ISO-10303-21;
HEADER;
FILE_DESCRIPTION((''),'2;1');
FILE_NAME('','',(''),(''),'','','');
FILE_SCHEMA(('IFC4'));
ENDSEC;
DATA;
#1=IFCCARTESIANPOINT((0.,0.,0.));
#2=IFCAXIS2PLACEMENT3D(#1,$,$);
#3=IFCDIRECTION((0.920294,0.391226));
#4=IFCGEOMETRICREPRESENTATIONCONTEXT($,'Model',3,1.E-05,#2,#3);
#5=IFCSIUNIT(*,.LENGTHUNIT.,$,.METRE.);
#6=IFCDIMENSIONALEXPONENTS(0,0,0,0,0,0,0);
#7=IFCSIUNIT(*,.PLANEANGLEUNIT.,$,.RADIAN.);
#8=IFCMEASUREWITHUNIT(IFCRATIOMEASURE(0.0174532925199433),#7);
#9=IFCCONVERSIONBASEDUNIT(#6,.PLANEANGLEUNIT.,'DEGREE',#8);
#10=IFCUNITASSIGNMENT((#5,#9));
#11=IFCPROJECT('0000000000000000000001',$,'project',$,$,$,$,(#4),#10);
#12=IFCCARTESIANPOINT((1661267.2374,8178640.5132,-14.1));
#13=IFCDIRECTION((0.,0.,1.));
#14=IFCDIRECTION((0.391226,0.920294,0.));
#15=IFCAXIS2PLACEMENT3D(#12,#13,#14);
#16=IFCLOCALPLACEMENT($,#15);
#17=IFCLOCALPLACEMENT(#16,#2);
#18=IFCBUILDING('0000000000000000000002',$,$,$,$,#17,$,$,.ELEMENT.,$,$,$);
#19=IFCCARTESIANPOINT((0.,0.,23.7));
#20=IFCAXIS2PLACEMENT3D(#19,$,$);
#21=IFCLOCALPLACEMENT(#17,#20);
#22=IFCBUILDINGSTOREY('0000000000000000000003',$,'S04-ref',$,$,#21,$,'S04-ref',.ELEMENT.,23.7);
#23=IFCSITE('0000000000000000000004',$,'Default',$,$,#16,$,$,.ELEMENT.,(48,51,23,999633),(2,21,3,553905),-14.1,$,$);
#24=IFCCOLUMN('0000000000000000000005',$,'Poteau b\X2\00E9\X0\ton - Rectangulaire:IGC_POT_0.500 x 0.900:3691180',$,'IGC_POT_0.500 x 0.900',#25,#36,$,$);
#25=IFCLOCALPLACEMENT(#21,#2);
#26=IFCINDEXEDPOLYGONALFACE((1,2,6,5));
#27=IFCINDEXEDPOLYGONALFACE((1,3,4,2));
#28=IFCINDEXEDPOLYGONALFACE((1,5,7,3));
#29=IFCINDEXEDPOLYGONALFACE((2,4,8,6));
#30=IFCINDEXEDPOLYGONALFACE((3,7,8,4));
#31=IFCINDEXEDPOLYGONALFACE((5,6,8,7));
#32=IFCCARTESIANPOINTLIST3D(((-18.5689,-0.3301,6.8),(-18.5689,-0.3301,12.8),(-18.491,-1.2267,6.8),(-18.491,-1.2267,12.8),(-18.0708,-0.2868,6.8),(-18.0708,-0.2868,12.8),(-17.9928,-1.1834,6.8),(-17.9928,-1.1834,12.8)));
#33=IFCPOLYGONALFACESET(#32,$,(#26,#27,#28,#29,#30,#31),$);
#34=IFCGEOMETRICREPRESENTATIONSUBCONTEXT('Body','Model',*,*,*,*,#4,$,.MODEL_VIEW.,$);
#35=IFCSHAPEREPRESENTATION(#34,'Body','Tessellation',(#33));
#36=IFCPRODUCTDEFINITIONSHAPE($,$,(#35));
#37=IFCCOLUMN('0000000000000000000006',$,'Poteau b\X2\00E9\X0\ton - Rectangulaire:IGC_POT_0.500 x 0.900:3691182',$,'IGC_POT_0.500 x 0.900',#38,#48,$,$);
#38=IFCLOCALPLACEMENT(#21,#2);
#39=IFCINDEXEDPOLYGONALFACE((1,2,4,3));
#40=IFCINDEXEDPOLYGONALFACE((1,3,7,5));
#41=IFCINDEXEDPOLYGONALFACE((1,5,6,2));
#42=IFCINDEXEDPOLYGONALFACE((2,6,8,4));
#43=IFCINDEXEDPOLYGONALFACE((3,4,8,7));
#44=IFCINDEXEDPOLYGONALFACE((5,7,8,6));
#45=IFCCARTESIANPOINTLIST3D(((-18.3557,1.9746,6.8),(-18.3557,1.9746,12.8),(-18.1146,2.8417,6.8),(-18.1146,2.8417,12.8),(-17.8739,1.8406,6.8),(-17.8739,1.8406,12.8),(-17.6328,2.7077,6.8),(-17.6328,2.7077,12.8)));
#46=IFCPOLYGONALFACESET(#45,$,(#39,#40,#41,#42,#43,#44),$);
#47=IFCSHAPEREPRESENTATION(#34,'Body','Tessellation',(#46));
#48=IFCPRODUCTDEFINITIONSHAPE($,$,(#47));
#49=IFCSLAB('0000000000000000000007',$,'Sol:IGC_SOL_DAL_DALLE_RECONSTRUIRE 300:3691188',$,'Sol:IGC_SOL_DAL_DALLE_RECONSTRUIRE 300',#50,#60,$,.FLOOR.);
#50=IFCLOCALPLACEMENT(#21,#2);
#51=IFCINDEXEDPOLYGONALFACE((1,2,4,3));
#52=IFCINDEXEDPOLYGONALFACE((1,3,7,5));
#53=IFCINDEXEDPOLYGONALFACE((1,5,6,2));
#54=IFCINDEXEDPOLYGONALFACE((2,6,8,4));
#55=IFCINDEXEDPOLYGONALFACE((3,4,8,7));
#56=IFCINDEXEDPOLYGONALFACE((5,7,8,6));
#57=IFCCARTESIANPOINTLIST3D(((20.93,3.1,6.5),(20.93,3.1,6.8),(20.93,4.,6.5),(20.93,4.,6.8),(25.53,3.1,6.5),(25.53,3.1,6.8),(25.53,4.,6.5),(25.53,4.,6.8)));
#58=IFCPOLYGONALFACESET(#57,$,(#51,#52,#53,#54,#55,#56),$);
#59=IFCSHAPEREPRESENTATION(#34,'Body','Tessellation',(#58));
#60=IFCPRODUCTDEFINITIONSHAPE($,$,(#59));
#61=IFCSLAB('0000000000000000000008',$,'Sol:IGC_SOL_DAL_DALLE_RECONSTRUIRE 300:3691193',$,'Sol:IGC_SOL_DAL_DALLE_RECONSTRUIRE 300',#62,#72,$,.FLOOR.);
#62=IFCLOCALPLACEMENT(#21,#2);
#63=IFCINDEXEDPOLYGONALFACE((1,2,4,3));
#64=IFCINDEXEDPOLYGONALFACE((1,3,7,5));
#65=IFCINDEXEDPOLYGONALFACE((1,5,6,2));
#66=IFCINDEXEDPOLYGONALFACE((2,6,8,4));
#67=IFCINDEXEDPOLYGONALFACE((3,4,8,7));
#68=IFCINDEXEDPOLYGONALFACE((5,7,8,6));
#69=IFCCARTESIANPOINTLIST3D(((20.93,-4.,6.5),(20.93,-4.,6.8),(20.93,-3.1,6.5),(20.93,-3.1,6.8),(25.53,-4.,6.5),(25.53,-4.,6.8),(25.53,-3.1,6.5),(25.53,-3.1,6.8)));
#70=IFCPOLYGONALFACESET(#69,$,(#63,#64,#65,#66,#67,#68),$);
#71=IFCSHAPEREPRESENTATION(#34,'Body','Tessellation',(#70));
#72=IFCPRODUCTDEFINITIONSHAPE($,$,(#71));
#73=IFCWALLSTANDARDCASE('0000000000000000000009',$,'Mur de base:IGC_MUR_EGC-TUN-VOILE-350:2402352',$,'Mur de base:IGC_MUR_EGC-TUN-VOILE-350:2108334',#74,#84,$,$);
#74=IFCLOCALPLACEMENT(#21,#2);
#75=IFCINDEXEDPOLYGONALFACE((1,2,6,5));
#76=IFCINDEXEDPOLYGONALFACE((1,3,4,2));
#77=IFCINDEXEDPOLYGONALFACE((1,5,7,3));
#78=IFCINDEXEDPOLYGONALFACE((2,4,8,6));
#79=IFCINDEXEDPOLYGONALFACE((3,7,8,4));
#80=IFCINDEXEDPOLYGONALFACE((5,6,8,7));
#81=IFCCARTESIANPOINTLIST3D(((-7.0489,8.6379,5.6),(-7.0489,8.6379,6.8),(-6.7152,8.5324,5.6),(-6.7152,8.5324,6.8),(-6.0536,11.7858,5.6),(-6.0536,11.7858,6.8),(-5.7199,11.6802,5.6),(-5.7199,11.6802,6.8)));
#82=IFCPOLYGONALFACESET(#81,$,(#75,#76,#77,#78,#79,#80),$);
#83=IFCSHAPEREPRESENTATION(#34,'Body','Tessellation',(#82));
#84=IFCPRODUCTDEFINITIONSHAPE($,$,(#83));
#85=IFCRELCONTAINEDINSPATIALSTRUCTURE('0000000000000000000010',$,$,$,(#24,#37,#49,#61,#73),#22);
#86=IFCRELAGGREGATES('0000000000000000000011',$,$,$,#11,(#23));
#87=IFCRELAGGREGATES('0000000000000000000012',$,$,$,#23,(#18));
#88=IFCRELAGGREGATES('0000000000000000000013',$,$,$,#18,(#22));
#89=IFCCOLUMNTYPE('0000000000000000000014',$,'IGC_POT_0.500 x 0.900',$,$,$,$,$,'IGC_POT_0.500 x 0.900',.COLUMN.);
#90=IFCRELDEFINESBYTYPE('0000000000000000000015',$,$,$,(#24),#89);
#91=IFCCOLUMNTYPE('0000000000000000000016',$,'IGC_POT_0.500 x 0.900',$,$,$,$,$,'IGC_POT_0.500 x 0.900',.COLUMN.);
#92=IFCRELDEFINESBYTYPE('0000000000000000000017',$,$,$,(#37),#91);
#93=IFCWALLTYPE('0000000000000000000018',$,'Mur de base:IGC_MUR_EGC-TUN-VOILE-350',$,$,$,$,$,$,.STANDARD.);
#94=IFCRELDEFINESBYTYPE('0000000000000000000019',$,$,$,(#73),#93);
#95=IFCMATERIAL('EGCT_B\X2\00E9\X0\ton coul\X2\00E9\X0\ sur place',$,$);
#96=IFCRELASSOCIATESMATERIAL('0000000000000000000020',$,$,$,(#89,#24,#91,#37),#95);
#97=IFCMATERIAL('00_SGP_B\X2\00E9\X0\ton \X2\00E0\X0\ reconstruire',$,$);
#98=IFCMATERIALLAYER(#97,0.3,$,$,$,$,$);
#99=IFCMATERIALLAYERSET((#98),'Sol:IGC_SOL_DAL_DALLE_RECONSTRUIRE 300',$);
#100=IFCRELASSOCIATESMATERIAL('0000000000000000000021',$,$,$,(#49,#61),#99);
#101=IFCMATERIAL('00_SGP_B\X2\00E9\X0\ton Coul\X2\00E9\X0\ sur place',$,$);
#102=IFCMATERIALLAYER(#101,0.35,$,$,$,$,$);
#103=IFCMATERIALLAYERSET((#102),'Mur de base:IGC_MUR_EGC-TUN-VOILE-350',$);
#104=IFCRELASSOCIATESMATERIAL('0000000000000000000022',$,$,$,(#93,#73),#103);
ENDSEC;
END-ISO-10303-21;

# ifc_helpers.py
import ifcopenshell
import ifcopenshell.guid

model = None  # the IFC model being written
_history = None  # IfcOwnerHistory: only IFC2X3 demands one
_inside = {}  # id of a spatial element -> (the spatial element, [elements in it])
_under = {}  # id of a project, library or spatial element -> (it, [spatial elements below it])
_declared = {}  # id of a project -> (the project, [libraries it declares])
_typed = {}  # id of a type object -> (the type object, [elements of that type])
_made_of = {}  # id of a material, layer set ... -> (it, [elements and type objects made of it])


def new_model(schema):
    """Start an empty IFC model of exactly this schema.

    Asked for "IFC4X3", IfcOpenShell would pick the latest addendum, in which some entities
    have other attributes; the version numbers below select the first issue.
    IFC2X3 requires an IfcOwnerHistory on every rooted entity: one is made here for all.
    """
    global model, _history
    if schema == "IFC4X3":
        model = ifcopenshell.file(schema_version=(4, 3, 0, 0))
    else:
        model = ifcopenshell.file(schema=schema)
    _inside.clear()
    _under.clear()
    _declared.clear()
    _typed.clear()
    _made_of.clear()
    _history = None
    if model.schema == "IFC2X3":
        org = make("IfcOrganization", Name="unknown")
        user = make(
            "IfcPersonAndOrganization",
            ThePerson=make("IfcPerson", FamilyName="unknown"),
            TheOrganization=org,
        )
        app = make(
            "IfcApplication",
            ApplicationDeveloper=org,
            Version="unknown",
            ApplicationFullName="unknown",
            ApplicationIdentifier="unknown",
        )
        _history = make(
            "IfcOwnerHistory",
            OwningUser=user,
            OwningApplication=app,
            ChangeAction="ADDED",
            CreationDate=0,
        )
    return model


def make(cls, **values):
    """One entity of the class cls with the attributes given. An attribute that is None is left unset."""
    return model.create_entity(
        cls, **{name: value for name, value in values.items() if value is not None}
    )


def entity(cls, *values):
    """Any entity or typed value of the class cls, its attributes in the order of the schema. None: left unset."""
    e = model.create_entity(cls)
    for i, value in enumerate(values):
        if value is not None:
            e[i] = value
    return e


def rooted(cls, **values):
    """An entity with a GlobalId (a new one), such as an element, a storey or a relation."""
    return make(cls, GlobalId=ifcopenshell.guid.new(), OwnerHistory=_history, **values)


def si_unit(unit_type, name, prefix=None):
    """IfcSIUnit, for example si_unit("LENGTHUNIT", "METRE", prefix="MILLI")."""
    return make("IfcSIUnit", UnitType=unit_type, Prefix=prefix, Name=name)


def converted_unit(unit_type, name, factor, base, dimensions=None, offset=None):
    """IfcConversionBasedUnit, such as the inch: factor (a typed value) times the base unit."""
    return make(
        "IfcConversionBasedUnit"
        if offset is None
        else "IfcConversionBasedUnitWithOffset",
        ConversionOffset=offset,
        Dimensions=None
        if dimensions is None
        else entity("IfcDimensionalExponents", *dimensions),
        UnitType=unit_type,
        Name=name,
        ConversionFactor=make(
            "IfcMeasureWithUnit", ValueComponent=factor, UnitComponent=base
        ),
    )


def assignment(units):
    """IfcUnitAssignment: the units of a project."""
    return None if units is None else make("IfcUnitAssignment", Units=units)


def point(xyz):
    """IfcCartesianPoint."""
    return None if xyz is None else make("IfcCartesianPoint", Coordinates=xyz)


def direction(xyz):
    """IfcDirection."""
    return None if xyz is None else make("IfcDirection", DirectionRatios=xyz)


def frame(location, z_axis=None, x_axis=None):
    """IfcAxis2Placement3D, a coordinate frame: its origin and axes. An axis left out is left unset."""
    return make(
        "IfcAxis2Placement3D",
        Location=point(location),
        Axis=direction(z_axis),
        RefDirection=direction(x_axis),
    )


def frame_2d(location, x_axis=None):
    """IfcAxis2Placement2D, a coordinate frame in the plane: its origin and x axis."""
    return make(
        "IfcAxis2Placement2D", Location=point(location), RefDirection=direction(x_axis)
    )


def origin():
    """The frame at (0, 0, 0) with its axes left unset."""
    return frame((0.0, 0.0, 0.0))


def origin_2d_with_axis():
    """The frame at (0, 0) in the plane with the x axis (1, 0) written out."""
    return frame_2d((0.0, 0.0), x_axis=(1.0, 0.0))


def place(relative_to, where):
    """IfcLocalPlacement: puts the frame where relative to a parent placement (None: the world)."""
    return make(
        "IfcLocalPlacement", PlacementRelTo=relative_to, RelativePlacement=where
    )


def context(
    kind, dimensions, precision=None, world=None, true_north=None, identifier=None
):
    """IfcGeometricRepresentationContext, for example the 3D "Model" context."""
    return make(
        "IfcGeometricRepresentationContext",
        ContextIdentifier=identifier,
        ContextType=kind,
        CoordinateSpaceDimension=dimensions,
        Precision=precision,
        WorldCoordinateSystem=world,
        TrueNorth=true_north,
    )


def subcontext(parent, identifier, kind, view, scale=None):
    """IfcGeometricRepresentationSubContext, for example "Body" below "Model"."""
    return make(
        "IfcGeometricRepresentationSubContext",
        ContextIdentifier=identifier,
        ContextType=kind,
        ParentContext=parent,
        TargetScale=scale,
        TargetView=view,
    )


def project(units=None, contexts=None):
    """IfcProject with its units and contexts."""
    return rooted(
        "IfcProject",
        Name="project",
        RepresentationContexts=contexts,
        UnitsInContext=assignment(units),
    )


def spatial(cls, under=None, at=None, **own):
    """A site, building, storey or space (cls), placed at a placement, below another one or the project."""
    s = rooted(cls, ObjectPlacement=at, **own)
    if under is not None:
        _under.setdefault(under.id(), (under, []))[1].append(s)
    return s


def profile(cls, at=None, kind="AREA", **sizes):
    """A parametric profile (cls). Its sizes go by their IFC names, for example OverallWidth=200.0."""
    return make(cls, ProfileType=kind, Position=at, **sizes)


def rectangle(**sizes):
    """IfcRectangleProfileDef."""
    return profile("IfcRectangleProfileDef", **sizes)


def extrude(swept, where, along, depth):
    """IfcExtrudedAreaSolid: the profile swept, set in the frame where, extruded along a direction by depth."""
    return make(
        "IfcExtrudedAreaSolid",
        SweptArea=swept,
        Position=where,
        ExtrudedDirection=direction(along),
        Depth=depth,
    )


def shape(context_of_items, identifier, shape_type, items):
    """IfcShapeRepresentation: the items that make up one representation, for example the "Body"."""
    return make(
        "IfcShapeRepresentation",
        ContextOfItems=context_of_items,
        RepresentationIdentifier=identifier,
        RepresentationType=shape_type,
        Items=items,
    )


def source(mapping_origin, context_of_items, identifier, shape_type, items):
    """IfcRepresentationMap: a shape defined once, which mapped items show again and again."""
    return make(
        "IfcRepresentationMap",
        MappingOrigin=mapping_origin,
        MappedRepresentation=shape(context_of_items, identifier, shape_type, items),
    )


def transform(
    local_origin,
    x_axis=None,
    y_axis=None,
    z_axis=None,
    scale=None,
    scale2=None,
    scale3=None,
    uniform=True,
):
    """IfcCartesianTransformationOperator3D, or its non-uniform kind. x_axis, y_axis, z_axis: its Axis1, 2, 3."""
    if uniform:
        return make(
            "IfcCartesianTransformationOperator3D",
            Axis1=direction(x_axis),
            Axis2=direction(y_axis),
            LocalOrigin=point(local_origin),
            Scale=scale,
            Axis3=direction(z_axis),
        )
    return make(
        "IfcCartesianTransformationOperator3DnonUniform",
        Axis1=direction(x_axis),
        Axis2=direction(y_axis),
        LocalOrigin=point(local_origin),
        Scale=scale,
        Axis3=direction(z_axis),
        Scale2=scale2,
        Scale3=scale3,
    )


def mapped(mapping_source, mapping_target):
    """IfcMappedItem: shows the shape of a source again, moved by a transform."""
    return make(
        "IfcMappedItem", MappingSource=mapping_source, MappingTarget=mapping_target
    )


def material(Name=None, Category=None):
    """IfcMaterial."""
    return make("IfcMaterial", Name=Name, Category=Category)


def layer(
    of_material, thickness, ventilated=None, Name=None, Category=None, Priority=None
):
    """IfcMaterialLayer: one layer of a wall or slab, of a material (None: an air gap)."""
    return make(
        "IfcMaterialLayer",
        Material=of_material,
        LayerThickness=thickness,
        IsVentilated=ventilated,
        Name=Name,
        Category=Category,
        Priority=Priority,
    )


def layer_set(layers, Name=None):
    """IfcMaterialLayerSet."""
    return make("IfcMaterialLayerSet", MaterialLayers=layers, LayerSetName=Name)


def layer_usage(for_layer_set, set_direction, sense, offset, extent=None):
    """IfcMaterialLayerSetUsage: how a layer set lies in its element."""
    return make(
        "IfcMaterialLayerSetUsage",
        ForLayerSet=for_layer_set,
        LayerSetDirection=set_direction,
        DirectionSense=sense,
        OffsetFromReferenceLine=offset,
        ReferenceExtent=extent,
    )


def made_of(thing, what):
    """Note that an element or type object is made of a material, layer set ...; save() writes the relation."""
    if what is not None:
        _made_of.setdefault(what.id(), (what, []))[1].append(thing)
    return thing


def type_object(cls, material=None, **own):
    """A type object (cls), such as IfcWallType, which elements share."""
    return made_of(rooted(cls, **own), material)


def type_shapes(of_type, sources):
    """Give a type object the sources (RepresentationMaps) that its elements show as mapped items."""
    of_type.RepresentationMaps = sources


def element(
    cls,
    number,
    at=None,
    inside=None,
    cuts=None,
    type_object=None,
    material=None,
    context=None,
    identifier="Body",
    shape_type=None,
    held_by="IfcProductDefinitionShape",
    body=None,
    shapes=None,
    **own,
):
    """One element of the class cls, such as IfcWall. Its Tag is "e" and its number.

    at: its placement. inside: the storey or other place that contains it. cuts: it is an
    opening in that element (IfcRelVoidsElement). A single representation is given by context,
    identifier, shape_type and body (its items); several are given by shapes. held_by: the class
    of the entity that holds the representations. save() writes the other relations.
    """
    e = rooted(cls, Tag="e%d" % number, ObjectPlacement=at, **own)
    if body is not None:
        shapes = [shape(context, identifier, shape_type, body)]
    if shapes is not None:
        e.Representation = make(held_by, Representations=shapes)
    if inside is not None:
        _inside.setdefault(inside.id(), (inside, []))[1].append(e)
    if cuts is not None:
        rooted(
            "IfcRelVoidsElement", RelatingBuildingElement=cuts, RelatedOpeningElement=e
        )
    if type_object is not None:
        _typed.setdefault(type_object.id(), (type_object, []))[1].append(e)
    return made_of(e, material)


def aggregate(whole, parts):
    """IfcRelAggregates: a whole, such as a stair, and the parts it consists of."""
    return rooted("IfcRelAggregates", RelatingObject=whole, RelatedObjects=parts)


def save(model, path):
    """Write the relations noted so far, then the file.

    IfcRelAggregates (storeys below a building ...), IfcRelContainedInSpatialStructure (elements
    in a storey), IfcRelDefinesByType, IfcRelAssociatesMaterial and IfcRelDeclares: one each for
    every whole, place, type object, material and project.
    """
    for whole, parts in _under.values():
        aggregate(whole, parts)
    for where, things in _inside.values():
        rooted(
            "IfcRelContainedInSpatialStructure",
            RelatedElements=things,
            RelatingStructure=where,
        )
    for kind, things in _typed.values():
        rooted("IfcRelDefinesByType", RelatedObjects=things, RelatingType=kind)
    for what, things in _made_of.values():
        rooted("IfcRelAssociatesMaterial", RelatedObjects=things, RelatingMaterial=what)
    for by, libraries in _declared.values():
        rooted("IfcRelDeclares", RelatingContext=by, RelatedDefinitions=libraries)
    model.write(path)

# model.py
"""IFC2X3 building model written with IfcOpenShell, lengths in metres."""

from ifc_helpers import new_model, entity, si_unit, converted_unit, direction, frame, frame_2d, origin, origin_2d_with_axis, place, context, subcontext, project, spatial, rectangle, extrude, source, transform, mapped, material, layer, layer_set, layer_usage, type_object, type_shapes, element, save


model = new_model("IFC2X3")

# Units and contexts
model_context = context("Model", 3, precision=1e-05, world=origin(), true_north=direction((0.920294, 0.391226)))
body_context = subcontext(model_context, "Body", "Model", "MODEL_VIEW")
ifc_project = project(units=[si_unit("LENGTHUNIT", "METRE"), converted_unit("PLANEANGLEUNIT", "DEGREE", entity("IfcRatioMeasure", 0.0174532925199433), si_unit("PLANEANGLEUNIT", "RADIAN"), dimensions=[0, 0, 0, 0, 0, 0, 0])], contexts=[model_context])

# Site, building, storey
site_placement = place(None, frame((1661267.2374, 8178640.5132, -14.1), z_axis=(0.0, 0.0, 1.0), x_axis=(0.391226, 0.920294, 0.0)))
site = spatial("IfcSite", under=ifc_project, at=site_placement, Name="Default", CompositionType="ELEMENT", RefLatitude=(48, 51, 23, 999633), RefLongitude=(2, 21, 3, 553905), RefElevation=-14.1)
building_placement = place(site_placement, origin())
building = spatial("IfcBuilding", under=site, at=building_placement, CompositionType="ELEMENT")
storey_placement = place(building_placement, frame((0.0, 0.0, 23.7)))
storey = spatial("IfcBuildingStorey", under=building, at=storey_placement, Name="S04-ref", LongName="S04-ref", CompositionType="ELEMENT", Elevation=23.7)

# Columns
ifc_material_1 = material(Name="EGCT_Béton coulé sur place")
column_type_1 = type_object("IfcColumnType", Name="IGC_POT_0.500 x 0.900", ElementType="IGC_POT_0.500 x 0.900", PredefinedType="COLUMN", material=ifc_material_1)
shared_shape_1 = source(origin(), body_context, "Body", "SweptSolid", [
    extrude(rectangle(XDim=0.9, YDim=0.5, at=frame_2d((0.0, 0.0), x_axis=(1.0, 0.0))), frame((-18.2809, -0.7567, 30.5), z_axis=(0.0, 0.0, 1.0), x_axis=(-0.086594, 0.996244, 0.0)), (0.0, 0.0, 1.0), 6.0),
])
type_shapes(column_type_1, [shared_shape_1])
column_1_placement = place(storey_placement, frame((0.0, 0.0, -23.7)))
element("IfcColumn", 1, at=column_1_placement, inside=storey, type_object=column_type_1, material=ifc_material_1, Name="Poteau béton - Rectangulaire:IGC_POT_0.500 x 0.900:3691180", ObjectType="IGC_POT_0.500 x 0.900", context=body_context, shape_type="MappedRepresentation", body=[
    mapped(shared_shape_1, transform((0.0, 0.0, 0.0), scale=1.0)),
])
column_type_2 = type_object("IfcColumnType", Name="IGC_POT_0.500 x 0.900", ElementType="IGC_POT_0.500 x 0.900", PredefinedType="COLUMN", material=ifc_material_1)
shared_shape_2 = source(origin(), body_context, "Body", "SweptSolid", [
    extrude(rectangle(XDim=0.5, YDim=0.9, at=frame_2d((0.0, 0.0), x_axis=(1.0, 0.0))), frame((-17.9943, 2.3411, 30.5), z_axis=(0.0, 0.0, 1.0), x_axis=(-0.963446, 0.267904, 0.0)), (0.0, 0.0, 1.0), 6.0),
])
type_shapes(column_type_2, [shared_shape_2])
column_2_placement = place(storey_placement, frame((0.0, 0.0, -23.7)))
element("IfcColumn", 2, at=column_2_placement, inside=storey, type_object=column_type_2, material=ifc_material_1, Name="Poteau béton - Rectangulaire:IGC_POT_0.500 x 0.900:3691182", ObjectType="IGC_POT_0.500 x 0.900", context=body_context, shape_type="MappedRepresentation", body=[
    mapped(shared_shape_2, transform((0.0, 0.0, 0.0), scale=1.0)),
])

# Slabs
ifc_material_2 = material(Name="00_SGP_Béton Coulé sur place")
ifc_material_3 = material(Name="00_SGP_Béton à reconstruire")
ifc_layer_1 = layer(ifc_material_3, 0.3)
ifc_layer_set_1 = layer_set([ifc_layer_1], Name="Sol:IGC_SOL_DAL_DALLE_RECONSTRUIRE 300")
ifc_layer_usage_1 = layer_usage(ifc_layer_set_1, "AXIS3", "POSITIVE", 0.0)
slab_1_placement = place(storey_placement, origin())
element("IfcSlab", 3, at=slab_1_placement, inside=storey, material=ifc_layer_usage_1, Name="Sol:IGC_SOL_DAL_DALLE_RECONSTRUIRE 300:3691188", ObjectType="Sol:IGC_SOL_DAL_DALLE_RECONSTRUIRE 300", PredefinedType="FLOOR", context=body_context, shape_type="SweptSolid", body=[
    extrude(rectangle(XDim=0.9, YDim=4.6, at=origin_2d_with_axis()), frame((23.23, 3.55, 6.8), z_axis=(0.0, 0.0, -1.0), x_axis=(0.0, 1.0, 0.0)), (0.0, 0.0, 1.0), 0.3),
])
ifc_layer_usage_2 = layer_usage(ifc_layer_set_1, "AXIS3", "POSITIVE", 0.0)
slab_2_placement = place(storey_placement, origin())
element("IfcSlab", 4, at=slab_2_placement, inside=storey, material=ifc_layer_usage_2, Name="Sol:IGC_SOL_DAL_DALLE_RECONSTRUIRE 300:3691193", ObjectType="Sol:IGC_SOL_DAL_DALLE_RECONSTRUIRE 300", PredefinedType="FLOOR", context=body_context, shape_type="SweptSolid", body=[
    extrude(rectangle(XDim=0.9, YDim=4.6, at=frame_2d((0.0, 0.0), x_axis=(1.0, 0.0))), frame((23.23, -3.55, 6.8), z_axis=(0.0, 0.0, -1.0), x_axis=(0.0, 1.0, 0.0)), (0.0, 0.0, 1.0), 0.3),
])

# Wall
ifc_layer_2 = layer(ifc_material_2, 0.35)
ifc_layer_set_2 = layer_set([ifc_layer_2], Name="Mur de base:IGC_MUR_EGC-TUN-VOILE-350")
ifc_layer_usage_3 = layer_usage(ifc_layer_set_2, "AXIS2", "POSITIVE", -0.175)
wall_type = type_object("IfcWallType", Name="Mur de base:IGC_MUR_EGC-TUN-VOILE-350", PredefinedType="STANDARD", material=ifc_layer_set_2)
wall_1_placement = place(storey_placement, frame((-6.8821, 8.5851, 5.6), z_axis=(0.0, 0.0, 1.0), x_axis=(0.301469, 0.953476, 0.0)))
element("IfcWallStandardCase", 5, at=wall_1_placement, inside=storey, type_object=wall_type, material=ifc_layer_usage_3, Name="Mur de base:IGC_MUR_EGC-TUN-VOILE-350:2402352", ObjectType="Mur de base:IGC_MUR_EGC-TUN-VOILE-350:2108334", context=body_context, shape_type="SweptSolid", body=[
    extrude(rectangle(XDim=3.3015, YDim=0.35, at=frame_2d((1.6507, 0.0), x_axis=(-1.0, 0.0))), origin(), (0.0, 0.0, 1.0), 1.2),
])

save(model, "model.ifc")
